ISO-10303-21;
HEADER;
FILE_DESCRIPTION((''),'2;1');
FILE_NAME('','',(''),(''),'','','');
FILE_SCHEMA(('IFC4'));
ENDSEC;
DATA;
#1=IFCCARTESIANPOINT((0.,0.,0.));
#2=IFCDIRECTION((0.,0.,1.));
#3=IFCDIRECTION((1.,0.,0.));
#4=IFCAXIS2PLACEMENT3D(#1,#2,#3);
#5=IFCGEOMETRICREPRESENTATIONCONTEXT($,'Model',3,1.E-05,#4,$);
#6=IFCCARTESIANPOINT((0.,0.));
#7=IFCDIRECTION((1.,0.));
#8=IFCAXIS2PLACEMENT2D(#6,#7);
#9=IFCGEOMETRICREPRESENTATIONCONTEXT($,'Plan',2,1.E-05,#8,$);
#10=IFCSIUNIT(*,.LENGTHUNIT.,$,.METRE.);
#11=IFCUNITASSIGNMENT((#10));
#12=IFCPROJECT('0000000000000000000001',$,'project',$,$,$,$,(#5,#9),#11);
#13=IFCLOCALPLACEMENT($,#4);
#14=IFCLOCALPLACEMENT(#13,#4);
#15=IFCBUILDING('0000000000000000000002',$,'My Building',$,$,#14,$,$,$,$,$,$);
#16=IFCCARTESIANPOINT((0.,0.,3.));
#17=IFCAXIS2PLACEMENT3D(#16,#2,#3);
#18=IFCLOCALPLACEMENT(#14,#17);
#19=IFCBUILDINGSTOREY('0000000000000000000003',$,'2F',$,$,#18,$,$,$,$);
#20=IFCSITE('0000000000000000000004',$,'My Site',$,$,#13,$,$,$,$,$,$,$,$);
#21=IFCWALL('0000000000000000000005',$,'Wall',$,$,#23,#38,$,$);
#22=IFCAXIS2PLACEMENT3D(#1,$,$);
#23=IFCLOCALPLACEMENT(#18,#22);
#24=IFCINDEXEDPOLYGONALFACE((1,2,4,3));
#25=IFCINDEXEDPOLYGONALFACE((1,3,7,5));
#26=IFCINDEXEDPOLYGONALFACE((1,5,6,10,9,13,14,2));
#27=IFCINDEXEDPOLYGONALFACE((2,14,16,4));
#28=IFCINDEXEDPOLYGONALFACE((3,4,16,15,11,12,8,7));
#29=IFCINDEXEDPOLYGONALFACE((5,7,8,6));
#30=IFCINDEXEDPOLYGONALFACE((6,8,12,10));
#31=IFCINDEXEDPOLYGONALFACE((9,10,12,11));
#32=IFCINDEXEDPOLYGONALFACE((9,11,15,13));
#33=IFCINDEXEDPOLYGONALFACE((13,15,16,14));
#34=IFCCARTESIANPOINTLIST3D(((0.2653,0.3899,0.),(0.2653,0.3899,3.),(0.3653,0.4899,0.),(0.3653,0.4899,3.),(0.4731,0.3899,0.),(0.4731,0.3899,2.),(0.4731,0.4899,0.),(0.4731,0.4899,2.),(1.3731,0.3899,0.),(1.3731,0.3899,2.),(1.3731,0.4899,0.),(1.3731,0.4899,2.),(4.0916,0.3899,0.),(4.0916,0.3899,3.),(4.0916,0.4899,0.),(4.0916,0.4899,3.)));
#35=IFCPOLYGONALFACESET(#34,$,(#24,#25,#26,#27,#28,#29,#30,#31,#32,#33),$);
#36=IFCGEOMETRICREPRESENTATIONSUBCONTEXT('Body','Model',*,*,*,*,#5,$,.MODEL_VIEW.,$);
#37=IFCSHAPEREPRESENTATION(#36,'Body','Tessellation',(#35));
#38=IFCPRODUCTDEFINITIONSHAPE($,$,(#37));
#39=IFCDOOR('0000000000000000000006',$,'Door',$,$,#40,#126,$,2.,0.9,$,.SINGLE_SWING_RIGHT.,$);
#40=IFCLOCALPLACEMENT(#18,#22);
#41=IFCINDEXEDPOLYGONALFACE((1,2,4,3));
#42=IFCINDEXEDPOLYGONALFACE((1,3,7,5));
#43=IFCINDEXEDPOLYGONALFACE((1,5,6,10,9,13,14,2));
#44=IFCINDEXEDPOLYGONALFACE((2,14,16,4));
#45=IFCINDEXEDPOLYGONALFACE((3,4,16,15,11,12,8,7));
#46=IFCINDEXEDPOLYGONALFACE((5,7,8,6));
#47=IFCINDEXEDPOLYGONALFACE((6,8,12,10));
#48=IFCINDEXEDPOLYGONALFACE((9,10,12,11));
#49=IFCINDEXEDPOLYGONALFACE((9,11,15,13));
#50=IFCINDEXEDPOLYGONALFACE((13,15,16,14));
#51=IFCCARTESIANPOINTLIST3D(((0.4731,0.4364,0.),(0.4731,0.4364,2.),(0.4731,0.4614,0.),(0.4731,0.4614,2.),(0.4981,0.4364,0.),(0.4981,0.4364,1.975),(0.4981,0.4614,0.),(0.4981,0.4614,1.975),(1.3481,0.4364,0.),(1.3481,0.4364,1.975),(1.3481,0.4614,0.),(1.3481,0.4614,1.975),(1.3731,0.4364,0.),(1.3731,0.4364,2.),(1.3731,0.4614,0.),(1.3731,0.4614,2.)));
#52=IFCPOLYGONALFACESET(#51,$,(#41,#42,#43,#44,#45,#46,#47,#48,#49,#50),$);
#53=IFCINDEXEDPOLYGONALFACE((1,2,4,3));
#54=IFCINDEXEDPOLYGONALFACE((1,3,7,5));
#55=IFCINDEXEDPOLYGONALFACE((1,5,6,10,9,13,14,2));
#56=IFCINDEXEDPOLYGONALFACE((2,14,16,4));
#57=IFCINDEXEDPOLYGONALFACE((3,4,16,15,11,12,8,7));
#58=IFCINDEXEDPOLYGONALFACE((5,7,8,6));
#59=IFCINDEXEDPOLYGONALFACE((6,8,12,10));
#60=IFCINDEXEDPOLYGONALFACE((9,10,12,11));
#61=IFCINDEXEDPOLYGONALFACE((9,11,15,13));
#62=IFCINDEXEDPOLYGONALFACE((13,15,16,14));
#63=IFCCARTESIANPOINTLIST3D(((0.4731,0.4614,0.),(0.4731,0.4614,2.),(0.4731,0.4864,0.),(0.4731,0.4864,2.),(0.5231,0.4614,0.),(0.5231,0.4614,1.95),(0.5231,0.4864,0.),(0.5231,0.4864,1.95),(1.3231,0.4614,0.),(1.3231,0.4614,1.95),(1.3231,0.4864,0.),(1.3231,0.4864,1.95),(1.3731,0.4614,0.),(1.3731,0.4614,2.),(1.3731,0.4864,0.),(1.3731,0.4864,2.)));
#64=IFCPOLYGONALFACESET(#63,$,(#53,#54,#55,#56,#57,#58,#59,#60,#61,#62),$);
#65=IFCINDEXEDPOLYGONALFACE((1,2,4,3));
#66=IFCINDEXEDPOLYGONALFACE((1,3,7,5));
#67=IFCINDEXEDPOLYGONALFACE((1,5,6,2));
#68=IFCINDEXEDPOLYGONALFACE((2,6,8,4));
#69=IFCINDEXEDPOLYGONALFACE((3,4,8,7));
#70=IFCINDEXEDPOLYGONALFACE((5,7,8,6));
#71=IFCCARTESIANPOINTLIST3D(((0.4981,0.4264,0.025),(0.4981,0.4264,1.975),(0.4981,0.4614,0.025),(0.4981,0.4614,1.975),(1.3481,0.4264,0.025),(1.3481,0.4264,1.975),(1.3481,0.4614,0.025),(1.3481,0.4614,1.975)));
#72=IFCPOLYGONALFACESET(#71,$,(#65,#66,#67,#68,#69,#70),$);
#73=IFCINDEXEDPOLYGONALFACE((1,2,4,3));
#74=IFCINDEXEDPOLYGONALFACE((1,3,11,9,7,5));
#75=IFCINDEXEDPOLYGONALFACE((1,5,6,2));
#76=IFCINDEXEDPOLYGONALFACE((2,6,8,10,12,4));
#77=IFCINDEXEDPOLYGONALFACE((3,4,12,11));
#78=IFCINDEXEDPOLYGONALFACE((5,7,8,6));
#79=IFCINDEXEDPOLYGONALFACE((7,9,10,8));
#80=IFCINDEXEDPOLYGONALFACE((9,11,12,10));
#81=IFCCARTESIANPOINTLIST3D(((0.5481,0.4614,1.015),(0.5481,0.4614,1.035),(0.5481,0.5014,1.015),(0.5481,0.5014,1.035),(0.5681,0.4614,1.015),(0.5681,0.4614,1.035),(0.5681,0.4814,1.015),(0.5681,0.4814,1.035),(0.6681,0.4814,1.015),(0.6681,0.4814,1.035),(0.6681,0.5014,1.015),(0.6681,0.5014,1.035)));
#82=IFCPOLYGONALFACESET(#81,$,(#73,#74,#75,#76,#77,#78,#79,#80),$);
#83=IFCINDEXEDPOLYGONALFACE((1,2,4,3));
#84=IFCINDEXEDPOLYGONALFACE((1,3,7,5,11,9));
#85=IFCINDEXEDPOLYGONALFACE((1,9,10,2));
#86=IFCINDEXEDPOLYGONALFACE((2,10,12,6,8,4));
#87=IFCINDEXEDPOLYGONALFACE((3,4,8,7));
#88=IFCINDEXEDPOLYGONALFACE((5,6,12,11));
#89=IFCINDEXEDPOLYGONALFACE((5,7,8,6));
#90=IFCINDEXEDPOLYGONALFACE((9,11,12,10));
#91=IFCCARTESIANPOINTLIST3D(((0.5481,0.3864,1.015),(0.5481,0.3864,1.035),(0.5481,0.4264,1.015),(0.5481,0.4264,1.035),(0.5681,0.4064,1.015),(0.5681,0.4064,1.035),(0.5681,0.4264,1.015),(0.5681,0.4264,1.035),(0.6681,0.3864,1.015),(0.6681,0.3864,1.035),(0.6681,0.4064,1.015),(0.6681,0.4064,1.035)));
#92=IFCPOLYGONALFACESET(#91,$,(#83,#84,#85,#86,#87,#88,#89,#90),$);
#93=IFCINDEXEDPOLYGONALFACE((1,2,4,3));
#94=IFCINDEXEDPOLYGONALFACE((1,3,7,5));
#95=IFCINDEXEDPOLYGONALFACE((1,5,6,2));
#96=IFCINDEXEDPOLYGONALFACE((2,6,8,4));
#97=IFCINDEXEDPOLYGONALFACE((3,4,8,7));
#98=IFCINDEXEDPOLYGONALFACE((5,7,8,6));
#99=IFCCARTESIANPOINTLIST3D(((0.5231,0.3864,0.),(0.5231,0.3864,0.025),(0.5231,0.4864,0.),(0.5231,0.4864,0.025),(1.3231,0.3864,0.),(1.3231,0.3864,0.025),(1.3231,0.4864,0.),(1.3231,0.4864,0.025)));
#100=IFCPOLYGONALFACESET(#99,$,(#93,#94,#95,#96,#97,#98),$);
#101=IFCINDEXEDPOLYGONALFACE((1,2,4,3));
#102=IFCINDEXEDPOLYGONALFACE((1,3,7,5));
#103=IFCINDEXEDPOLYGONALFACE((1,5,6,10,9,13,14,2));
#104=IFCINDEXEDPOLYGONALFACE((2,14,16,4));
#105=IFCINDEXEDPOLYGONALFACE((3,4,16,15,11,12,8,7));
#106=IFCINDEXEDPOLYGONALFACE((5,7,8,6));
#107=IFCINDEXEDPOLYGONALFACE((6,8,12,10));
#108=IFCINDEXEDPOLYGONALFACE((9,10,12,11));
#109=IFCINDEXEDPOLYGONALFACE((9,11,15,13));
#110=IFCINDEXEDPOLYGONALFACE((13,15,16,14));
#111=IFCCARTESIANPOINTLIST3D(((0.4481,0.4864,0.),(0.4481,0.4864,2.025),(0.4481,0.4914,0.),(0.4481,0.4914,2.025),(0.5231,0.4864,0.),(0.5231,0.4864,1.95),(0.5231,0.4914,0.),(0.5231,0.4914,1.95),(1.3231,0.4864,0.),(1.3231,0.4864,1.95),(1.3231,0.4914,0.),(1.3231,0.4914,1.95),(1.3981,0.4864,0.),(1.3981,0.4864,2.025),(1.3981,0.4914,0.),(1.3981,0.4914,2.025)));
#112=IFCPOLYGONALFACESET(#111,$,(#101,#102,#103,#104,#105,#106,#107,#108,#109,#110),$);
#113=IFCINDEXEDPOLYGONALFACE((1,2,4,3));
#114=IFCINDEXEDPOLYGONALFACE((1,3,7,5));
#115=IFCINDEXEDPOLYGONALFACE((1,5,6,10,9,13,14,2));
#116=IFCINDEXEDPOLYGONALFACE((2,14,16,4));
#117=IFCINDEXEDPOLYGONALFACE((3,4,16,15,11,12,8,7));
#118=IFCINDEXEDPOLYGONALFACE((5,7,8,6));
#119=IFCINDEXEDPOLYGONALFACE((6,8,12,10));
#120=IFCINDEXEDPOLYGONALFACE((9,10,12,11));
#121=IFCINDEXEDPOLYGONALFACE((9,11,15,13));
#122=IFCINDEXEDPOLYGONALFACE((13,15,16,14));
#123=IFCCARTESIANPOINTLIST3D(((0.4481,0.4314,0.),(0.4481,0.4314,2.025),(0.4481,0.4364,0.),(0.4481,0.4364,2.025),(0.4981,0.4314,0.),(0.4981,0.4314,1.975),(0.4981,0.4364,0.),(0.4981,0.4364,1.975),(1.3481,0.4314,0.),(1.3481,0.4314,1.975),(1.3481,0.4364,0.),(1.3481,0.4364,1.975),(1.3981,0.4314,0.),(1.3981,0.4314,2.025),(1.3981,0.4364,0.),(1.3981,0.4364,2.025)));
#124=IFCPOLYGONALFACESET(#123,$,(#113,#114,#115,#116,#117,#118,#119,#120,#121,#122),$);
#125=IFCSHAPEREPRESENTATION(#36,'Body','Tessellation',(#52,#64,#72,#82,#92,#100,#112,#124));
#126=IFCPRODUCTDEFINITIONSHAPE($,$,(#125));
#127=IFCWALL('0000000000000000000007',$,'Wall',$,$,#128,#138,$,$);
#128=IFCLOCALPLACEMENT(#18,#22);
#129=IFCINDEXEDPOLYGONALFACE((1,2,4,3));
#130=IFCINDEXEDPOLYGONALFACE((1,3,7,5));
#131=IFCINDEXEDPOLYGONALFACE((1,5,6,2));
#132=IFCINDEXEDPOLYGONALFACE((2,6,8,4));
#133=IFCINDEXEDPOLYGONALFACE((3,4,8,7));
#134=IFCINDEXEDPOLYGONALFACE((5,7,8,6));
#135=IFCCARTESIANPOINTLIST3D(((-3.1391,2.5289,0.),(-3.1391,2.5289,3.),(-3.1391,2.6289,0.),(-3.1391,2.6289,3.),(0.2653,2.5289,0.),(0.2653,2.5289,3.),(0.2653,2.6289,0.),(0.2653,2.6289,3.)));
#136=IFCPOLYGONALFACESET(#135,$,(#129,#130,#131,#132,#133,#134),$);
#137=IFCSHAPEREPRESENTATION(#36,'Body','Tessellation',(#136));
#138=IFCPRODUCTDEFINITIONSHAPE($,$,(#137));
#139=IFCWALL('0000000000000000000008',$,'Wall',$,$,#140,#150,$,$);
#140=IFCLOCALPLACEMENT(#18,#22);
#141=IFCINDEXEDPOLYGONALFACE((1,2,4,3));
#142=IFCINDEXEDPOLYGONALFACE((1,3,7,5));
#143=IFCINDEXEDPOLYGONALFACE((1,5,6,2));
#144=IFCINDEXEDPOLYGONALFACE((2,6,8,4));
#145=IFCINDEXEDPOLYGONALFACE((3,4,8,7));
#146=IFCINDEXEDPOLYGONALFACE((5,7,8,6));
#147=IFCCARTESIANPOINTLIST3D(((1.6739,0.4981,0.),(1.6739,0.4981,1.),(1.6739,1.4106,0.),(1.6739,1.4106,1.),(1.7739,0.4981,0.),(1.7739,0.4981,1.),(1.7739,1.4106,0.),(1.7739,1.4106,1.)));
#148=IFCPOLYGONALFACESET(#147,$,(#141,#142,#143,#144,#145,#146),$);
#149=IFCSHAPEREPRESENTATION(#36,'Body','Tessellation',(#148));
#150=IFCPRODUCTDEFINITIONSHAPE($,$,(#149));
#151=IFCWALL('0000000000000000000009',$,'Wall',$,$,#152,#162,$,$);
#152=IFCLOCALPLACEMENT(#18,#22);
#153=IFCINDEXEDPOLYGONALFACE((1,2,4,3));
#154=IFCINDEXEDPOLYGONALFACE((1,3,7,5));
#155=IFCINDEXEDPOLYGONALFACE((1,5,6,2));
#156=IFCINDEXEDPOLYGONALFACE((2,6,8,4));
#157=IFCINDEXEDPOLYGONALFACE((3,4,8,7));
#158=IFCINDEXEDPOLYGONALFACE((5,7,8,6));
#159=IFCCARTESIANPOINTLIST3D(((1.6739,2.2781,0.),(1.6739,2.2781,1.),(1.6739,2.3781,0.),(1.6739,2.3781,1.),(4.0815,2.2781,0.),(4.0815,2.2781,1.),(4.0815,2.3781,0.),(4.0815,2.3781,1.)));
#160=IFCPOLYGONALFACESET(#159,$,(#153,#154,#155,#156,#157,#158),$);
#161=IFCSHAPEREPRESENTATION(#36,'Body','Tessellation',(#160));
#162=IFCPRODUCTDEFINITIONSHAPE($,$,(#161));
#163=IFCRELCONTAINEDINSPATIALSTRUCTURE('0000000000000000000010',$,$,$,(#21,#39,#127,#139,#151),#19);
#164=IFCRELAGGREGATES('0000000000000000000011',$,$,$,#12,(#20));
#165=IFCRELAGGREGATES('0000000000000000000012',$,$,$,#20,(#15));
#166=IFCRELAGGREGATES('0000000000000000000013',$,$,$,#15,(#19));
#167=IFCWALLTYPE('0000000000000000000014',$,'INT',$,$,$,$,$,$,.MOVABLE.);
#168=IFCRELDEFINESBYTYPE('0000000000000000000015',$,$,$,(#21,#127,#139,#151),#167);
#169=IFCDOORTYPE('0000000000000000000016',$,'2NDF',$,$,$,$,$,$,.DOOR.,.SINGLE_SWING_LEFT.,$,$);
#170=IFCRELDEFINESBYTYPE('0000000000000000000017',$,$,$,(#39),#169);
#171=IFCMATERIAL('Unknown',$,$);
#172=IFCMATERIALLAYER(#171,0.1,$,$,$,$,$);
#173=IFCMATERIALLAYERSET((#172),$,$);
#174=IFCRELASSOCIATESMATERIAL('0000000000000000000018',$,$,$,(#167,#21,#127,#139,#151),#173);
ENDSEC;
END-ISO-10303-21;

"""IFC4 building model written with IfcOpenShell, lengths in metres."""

from ifc_helpers import new_model, entity, si_unit, frame, origin_with_axes, origin_2d_with_axis, place, context, subcontext, project, spatial, line, indexed_curve, outline, extrude, shape, source, transform, mapped, material, layer, layer_set, layer_usage, type_object, type_shapes, element, fill, save


model = new_model("IFC4")

# Units and contexts
model_context = context("Model", 3, precision=1e-05, world=origin_with_axes())
plan_context = context("Plan", 2, precision=1e-05, world=origin_2d_with_axis())
body_context_1 = subcontext(model_context, "Body", "Model", "MODEL_VIEW")
body_context_2 = subcontext(plan_context, "Body", "Plan", "PLAN_VIEW")
ifc_project = project(units=[si_unit("LENGTHUNIT", "METRE")], contexts=[model_context, plan_context])

# Site, building, storey
site_placement = place(None, origin_with_axes())
site = spatial("IfcSite", under=ifc_project, at=site_placement, Name="My Site")
building_placement = place(site_placement, origin_with_axes())
building = spatial("IfcBuilding", under=site, at=building_placement, Name="My Building")
storey_placement = place(building_placement, frame((0.0, 0.0, 3.0), z_axis=(0.0, 0.0, 1.0), x_axis=(1.0, 0.0, 0.0)))
storey = spatial("IfcBuildingStorey", under=building, at=storey_placement, Name="2F")

# Shared definitions
ifc_material = material(Name="Unknown")

# Shared definitions
door_type_1 = type_object("IfcDoorType", Name="2NDF", OperationType="SINGLE_SWING_LEFT", PredefinedType="DOOR")
shared_shape_1 = source(origin_with_axes(), body_context_1, "Body", "SweptSolid", [
    extrude(outline(indexed_curve([(0.0, 0.0), (0.0, 2.0), (0.9, 2.0), (0.9, 0.0), (0.875, 0.0), (0.875, 1.975), (0.025, 1.975), (0.025, 0.0)], segments=[line(1, 2, 3, 4, 5, 6, 7, 8, 1)])), frame((0.0, 0.025, 0.0), z_axis=(0.0, -1.0, 0.0), x_axis=(1.0, 0.0, 0.0)), (0.0, 0.0, -1.0), 0.025),
    extrude(outline(indexed_curve([(0.0, 0.0), (0.0, 2.0), (0.9, 2.0), (0.9, 0.0), (0.85, 0.0), (0.85, 1.95), (0.05, 1.95), (0.05, 0.0)], segments=[line(1, 2, 3, 4, 5, 6, 7, 8, 1)])), frame((0.0, 0.0, 0.0), z_axis=(0.0, -1.0, 0.0), x_axis=(1.0, 0.0, 0.0)), (0.0, 0.0, -1.0), 0.025),
    extrude(outline(indexed_curve([(0.0, 0.0), (0.85, 0.0), (0.85, 0.035), (0.0, 0.035)], segments=[line(1, 2, 3, 4, 1)])), frame((0.025, 0.025, 0.025), z_axis=(0.0, 0.0, 1.0), x_axis=(1.0, 0.0, 0.0)), (0.0, 0.0, 1.0), 1.95),
    extrude(outline(indexed_curve([(0.0, 0.0), (0.0, -0.04), (-0.12, -0.04), (-0.12, -0.02), (-0.02, -0.02), (-0.02, 0.0)], segments=[line(1, 2, 3, 4, 5, 6, 1)])), frame((0.825, 0.025, 1.015), z_axis=(0.0, 0.0, 1.0), x_axis=(1.0, 0.0, 0.0)), (0.0, 0.0, 1.0), 0.02),
    extrude(outline(indexed_curve([(0.0, 0.0), (0.0, 0.04), (-0.12, 0.04), (-0.12, 0.02), (-0.02, 0.02), (-0.02, 0.0)], segments=[line(1, 2, 3, 4, 5, 6, 1)])), frame((0.825, 0.06, 1.015), z_axis=(0.0, 0.0, 1.0), x_axis=(1.0, 0.0, 0.0)), (0.0, 0.0, 1.0), 0.02),
    extrude(outline(indexed_curve([(0.0, 0.0), (0.8, 0.0), (0.8, 0.1), (0.0, 0.1)], segments=[line(1, 2, 3, 4, 1)])), frame((0.05, 0.0, 0.0), z_axis=(0.0, 0.0, 1.0), x_axis=(1.0, 0.0, 0.0)), (0.0, 0.0, 1.0), 0.025),
    extrude(outline(indexed_curve([(0.0, 0.0), (0.0, 2.025), (0.95, 2.025), (0.95, 0.0), (0.875, 0.0), (0.875, 1.95), (0.075, 1.95), (0.075, 0.0)], segments=[line(1, 2, 3, 4, 5, 6, 7, 8, 1)])), frame((-0.025, -0.005, 0.0), z_axis=(0.0, -1.0, 0.0), x_axis=(1.0, 0.0, 0.0)), (0.0, 0.0, -1.0), 0.005),
    extrude(outline(indexed_curve([(0.0, 0.0), (0.0, 2.025), (0.95, 2.025), (0.95, 0.0), (0.9, 0.0), (0.9, 1.975), (0.05, 1.975), (0.05, 0.0)], segments=[line(1, 2, 3, 4, 5, 6, 7, 8, 1)])), frame((-0.025, 0.05, 0.0), z_axis=(0.0, -1.0, 0.0), x_axis=(1.0, 0.0, 0.0)), (0.0, 0.0, -1.0), 0.005),
])
shared_shape_2 = source(origin_with_axes(), body_context_2, "Body", "Curve2D", [
    entity("IfcIndexedPolyCurve", entity("IfcCartesianPointList2D", [[0.0, 0.0], [0.0, 0.05], [0.025, 0.05], [0.025, 0.025], [0.05, 0.025], [0.05, 0.0]]), [entity("IfcLineIndex", [1, 2, 3, 4, 5, 6, 1])]),
    entity("IfcIndexedPolyCurve", entity("IfcCartesianPointList2D", [[0.9, 0.0], [0.9, 0.05], [0.875, 0.05], [0.875, 0.025], [0.85, 0.025], [0.85, 0.0]]), [entity("IfcLineIndex", [1, 2, 3, 4, 5, 6, 1])]),
    entity("IfcTrimmedCurve", entity("IfcEllipse", entity("IfcAxis2Placement2D", entity("IfcCartesianPoint", [0.06, 0.05]), entity("IfcDirection", [1.0, 0.0])), 0.815, 0.85), [entity("IfcCartesianPoint", [0.875, 0.05])], [entity("IfcCartesianPoint", [0.06, 0.9])], True, "CARTESIAN"),
    entity("IfcIndexedPolyCurve", entity("IfcCartesianPointList2D", [[0.025, 0.05], [0.06, 0.05], [0.06, 0.9], [0.025, 0.9]]), [entity("IfcLineIndex", [1, 2, 3, 4, 1])]),
])
type_shapes(door_type_1, [shared_shape_1, shared_shape_2])

# Wall, opening, door
ifc_layer_1 = layer(ifc_material, 0.1)
ifc_layer_set_1 = layer_set([ifc_layer_1])
ifc_layer_usage_1 = layer_usage(ifc_layer_set_1, "AXIS2", "POSITIVE", -0.1)
wall_type_1 = type_object("IfcWallType", Name="INT", PredefinedType="MOVABLE", material=ifc_layer_set_1)
wall_1_placement = place(storey_placement, frame((0.3653, 0.4899, 0.0), z_axis=(0.0, 0.0, 1.0), x_axis=(1.0, 0.0, 0.0)))
wall_1 = element("IfcWall", 1, at=wall_1_placement, inside=storey, type_object=wall_type_1, material=ifc_layer_usage_1, Name="Wall", context=body_context_1, shape_type="SweptSolid", body=[
    extrude(outline(indexed_curve([(-0.1, -0.1), (0.0, 0.0), (3.7262, 0.0), (3.7262, -0.1)], segments=[line(1, 2, 3, 4, 1)])), origin_with_axes(), (0.0, 0.0, 1.0), 3.0),
])
placement_1 = place(storey_placement, frame((1.3731, 0.4864, 0.0), z_axis=(0.0, 0.0, 1.0), x_axis=(-1.0, 0.0, 0.0)))
opening_1 = element("IfcOpeningElement", 2, at=placement_1, cuts=wall_1, PredefinedType="OPENING", context=body_context_1, shape_type="SweptSolid", body=[
    extrude(outline(indexed_curve([(0.0, 0.0), (0.9, 0.0), (0.9, 2.0), (0.0, 2.0)], segments=[line(1, 2, 3, 4, 1)])), frame((0.0, -0.6, 0.0), z_axis=(0.0, -1.0, 0.0), x_axis=(1.0, 0.0, 0.0)), (0.0, 0.0, -1.0), 1.2),
])
door_1 = element("IfcDoor", 3, at=placement_1, inside=storey, type_object=door_type_1, Name="Door", OperationType="SINGLE_SWING_RIGHT", OverallHeight=2.0, OverallWidth=0.9, shapes=[
    shape(body_context_1, "Body", "MappedRepresentation", [mapped(shared_shape_1, transform((0.0, 0.0, 0.0), x_axis=(1.0, 0.0, 0.0), y_axis=(0.0, 1.0, 0.0), z_axis=(0.0, 0.0, 1.0), scale=1.0))]),
    shape(body_context_2, "Body", "MappedRepresentation", [mapped(shared_shape_2, transform((0.0, 0.0, 0.0), x_axis=(1.0, 0.0, 0.0), y_axis=(0.0, 1.0, 0.0), z_axis=(0.0, 0.0, 1.0), scale=1.0))]),
])
fill(opening_1, door_1)

# Walls
ifc_layer_usage_2 = layer_usage(ifc_layer_set_1, "AXIS2", "POSITIVE", -0.1)
wall_2_placement = place(storey_placement, frame((-3.1391, 2.6289, 0.0), z_axis=(0.0, 0.0, 1.0), x_axis=(1.0, 0.0, 0.0)))
element("IfcWall", 4, at=wall_2_placement, inside=storey, type_object=wall_type_1, material=ifc_layer_usage_2, Name="Wall", context=body_context_1, shape_type="SweptSolid", body=[
    extrude(outline(indexed_curve([(0.0, -0.1), (0.0, 0.0), (3.4045, 0.0), (3.4045, -0.1)], segments=[line(1, 2, 3, 4, 1)])), origin_with_axes(), (0.0, 0.0, 1.0), 3.0),
])
ifc_layer_usage_3 = layer_usage(ifc_layer_set_1, "AXIS2", "POSITIVE", 0.0)
wall_3_placement = place(storey_placement, frame((1.6739, 1.4106, 0.0), z_axis=(0.0, 0.0, 1.0), x_axis=(0.0, -1.0, 0.0)))
element("IfcWall", 5, at=wall_3_placement, inside=storey, type_object=wall_type_1, material=ifc_layer_usage_3, Name="Wall", context=body_context_1, shape_type="SweptSolid", body=[
    extrude(outline(indexed_curve([(0.0, 0.0), (0.0, 0.1), (0.9125, 0.1), (0.9125, 0.0)], segments=[line(1, 2, 3, 4, 1)])), origin_with_axes(), (0.0, 0.0, 1.0), 1.0),
])
ifc_layer_usage_4 = layer_usage(ifc_layer_set_1, "AXIS2", "POSITIVE", 0.0)
wall_4_placement = place(storey_placement, frame((1.6739, 2.2781, 0.0), z_axis=(0.0, 0.0, 1.0), x_axis=(1.0, 0.0, 0.0)))
element("IfcWall", 6, at=wall_4_placement, inside=storey, type_object=wall_type_1, material=ifc_layer_usage_4, Name="Wall", context=body_context_1, shape_type="SweptSolid", body=[
    extrude(outline(indexed_curve([(0.0, 0.0), (0.0, 0.1), (2.4075, 0.1), (2.4075, 0.0)], segments=[line(1, 2, 3, 4, 1)])), origin_with_axes(), (0.0, 0.0, 1.0), 1.0),
])

save(model, "model.ifc")
